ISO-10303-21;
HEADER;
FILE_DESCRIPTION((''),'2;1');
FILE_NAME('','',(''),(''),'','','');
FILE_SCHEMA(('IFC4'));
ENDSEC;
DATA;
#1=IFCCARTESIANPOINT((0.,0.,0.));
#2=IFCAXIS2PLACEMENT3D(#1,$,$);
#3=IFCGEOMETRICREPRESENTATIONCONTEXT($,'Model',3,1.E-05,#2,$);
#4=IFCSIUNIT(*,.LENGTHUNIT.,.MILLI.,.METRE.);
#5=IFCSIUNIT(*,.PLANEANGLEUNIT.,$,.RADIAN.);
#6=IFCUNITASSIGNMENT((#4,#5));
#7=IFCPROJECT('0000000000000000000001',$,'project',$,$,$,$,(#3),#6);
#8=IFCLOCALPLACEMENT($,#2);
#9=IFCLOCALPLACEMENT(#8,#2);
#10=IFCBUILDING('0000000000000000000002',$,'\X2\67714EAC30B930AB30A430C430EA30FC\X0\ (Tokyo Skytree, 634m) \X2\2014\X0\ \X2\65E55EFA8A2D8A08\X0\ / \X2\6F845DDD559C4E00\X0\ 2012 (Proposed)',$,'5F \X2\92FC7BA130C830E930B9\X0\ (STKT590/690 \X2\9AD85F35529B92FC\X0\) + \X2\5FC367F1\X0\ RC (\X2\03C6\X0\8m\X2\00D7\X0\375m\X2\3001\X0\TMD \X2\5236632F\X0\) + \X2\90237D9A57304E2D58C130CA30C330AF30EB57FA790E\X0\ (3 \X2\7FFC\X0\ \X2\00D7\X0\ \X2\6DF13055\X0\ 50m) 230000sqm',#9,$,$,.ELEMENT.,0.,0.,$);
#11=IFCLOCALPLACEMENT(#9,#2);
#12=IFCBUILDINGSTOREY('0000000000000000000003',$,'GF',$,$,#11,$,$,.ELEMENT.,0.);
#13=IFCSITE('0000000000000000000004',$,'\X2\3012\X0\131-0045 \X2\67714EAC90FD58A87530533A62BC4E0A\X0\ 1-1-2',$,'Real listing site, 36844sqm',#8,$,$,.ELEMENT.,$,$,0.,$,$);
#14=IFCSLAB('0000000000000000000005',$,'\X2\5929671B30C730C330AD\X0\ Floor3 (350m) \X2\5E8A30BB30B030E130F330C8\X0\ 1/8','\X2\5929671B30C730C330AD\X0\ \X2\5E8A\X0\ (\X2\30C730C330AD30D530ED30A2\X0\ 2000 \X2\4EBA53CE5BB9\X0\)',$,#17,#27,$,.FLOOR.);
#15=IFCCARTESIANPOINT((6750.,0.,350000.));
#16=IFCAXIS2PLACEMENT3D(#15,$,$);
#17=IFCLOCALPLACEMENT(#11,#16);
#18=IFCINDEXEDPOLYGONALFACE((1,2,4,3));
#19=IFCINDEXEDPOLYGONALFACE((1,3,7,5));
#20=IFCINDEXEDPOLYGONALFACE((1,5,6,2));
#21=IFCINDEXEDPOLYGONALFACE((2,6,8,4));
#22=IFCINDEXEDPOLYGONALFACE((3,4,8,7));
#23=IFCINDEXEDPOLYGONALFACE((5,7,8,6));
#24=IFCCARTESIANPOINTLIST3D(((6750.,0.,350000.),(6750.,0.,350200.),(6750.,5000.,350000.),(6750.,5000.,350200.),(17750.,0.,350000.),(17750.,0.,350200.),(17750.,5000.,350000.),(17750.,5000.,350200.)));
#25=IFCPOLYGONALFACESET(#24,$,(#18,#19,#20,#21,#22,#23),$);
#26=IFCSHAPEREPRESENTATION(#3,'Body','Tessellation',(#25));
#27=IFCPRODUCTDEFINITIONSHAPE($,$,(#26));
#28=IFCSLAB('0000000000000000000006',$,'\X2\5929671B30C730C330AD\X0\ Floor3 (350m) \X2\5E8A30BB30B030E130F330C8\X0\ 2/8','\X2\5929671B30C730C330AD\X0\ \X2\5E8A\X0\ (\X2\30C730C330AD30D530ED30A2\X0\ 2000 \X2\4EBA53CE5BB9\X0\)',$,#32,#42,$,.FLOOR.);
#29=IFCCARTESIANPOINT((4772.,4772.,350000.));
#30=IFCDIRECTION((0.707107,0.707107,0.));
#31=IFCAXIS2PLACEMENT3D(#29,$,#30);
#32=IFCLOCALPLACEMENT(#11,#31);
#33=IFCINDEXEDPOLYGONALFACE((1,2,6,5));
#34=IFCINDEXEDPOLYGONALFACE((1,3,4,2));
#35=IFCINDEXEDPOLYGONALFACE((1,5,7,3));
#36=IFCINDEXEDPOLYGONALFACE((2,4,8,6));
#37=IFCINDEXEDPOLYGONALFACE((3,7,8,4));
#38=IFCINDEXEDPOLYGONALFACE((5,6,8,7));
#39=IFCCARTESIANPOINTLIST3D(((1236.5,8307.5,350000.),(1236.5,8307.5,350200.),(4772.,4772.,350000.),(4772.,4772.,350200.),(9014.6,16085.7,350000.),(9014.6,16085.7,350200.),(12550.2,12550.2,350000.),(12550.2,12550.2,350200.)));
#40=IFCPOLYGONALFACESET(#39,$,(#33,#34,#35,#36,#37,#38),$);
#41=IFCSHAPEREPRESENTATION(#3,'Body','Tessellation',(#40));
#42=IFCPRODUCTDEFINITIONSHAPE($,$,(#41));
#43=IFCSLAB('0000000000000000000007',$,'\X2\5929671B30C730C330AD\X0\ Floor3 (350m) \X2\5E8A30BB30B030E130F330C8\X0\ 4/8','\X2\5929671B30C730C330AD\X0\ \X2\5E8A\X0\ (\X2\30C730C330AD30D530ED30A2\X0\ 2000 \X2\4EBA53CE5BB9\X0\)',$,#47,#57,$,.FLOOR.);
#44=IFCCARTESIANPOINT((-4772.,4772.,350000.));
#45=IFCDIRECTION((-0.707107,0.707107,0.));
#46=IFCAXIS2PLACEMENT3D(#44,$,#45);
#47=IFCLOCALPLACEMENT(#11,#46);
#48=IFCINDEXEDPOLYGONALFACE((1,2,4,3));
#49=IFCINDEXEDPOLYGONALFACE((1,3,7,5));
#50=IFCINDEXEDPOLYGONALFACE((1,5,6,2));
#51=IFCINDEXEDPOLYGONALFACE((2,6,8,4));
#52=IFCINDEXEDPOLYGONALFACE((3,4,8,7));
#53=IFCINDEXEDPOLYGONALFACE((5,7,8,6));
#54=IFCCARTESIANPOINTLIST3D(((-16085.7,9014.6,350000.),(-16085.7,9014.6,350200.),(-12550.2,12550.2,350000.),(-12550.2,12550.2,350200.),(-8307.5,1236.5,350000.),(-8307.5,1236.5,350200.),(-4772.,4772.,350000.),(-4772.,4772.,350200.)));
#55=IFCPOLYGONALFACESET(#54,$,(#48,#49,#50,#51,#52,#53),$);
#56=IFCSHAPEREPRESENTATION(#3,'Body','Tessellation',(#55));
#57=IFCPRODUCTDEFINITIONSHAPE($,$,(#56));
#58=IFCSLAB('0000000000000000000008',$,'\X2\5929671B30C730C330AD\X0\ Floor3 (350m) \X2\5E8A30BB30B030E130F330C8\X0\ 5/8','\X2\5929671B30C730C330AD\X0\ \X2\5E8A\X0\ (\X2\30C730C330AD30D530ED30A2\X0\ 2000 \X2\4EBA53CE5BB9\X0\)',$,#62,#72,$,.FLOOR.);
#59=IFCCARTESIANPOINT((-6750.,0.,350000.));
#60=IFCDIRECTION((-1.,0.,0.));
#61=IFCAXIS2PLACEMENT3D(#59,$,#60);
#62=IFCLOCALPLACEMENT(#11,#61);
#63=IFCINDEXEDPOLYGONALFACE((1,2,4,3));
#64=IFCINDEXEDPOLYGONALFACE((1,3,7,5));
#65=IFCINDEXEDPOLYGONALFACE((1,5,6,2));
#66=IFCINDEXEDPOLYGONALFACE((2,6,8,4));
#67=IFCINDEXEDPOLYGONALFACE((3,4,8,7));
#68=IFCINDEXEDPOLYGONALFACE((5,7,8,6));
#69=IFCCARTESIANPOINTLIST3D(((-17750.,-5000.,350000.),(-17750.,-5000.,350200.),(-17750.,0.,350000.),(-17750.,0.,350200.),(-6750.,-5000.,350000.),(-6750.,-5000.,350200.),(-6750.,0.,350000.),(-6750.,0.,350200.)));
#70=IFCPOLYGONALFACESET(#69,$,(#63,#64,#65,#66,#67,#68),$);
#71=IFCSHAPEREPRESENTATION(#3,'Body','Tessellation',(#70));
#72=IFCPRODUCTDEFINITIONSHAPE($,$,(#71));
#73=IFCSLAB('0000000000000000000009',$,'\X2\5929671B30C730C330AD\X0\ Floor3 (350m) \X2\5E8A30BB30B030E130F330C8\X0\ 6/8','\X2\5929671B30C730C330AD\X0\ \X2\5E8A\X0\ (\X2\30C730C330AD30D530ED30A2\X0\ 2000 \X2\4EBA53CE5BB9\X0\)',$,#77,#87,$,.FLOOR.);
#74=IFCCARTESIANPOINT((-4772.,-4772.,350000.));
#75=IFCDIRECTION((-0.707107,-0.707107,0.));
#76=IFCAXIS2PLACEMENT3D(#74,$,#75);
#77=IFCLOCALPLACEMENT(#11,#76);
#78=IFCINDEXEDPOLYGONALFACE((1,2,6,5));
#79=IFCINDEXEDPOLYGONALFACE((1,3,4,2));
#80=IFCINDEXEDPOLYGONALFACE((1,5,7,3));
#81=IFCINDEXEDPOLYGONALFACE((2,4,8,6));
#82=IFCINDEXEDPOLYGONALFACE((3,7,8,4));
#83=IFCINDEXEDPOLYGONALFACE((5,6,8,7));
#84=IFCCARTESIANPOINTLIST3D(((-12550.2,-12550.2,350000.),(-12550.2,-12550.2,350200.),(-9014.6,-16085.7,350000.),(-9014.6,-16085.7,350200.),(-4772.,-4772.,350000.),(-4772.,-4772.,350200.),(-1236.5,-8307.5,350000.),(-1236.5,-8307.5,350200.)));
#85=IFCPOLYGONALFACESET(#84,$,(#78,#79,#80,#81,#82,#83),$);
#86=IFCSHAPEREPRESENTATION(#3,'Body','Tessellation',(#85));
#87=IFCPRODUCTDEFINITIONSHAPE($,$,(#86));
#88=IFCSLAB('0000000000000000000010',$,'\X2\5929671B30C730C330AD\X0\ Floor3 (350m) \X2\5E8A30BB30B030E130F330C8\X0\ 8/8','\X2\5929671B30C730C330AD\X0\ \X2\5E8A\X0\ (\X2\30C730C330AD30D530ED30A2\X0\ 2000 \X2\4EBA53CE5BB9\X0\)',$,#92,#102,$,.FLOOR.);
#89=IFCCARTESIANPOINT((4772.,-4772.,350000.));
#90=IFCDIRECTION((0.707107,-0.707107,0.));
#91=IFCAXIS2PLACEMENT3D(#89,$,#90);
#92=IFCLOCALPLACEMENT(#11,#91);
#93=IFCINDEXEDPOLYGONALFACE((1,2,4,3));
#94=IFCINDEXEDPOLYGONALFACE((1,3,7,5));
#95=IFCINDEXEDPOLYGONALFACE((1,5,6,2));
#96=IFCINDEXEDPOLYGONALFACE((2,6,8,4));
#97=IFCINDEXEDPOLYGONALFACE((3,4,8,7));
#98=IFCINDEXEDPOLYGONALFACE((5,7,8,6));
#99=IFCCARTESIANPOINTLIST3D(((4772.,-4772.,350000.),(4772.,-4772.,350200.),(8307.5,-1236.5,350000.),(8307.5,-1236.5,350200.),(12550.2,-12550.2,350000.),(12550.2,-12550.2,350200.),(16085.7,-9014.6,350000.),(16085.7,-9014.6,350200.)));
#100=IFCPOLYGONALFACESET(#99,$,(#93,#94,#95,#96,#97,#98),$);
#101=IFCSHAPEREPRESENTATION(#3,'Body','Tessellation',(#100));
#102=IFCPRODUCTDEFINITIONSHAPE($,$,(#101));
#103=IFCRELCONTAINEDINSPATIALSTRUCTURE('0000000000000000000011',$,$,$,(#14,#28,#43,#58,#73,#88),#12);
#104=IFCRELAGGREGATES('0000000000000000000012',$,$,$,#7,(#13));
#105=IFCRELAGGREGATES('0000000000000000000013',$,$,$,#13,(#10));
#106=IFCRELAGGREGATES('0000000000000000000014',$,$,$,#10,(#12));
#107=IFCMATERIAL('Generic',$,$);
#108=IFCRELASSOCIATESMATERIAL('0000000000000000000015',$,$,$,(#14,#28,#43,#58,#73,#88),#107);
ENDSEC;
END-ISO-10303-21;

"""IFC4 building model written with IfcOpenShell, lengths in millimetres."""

from ifc_helpers import new_model, si_unit, frame, frame_2d, origin, place, context, project, spatial, rectangle, extrude, material, element, save


model = new_model("IFC4")

# Units and contexts
model_context = context("Model", 3, precision=1e-05, world=origin())
ifc_project = project(units=[si_unit("LENGTHUNIT", "METRE", prefix="MILLI"), si_unit("PLANEANGLEUNIT", "RADIAN")], contexts=[model_context])

# Site, building, storey
site_placement = place(None, origin())
site = spatial("IfcSite", under=ifc_project, at=site_placement, Name="〒131-0045 東京都墨田区押上 1-1-2", ObjectType="Real listing site, 36844sqm", CompositionType="ELEMENT", RefElevation=0.0)
building_placement = place(site_placement, origin())
building = spatial("IfcBuilding", under=site, at=building_placement, Name="東京スカイツリー (Tokyo Skytree, 634m) — 日建設計 / 澄川喜一 2012 (Proposed)", ObjectType="5F 鋼管トラス (STKT590/690 高張力鋼) + 心柱 RC (φ8m×375m、TMD 制振) + 連続地中壁ナックル基礎 (3 翼 × 深さ 50m) 230000sqm", CompositionType="ELEMENT", ElevationOfRefHeight=0.0, ElevationOfTerrain=0.0)
storey_placement = place(building_placement, origin())
storey = spatial("IfcBuildingStorey", under=building, at=storey_placement, Name="GF", CompositionType="ELEMENT", Elevation=0.0)

# Shared definitions
ifc_material_1 = material(Name="Generic")

# Slabs
slab_1_placement = place(storey_placement, frame((6750.0, 0.0, 350000.0)))
element("IfcSlab", 1, at=slab_1_placement, inside=storey, material=ifc_material_1, Name="天望デッキ Floor3 (350m) 床セグメント 1/8", Description="天望デッキ 床 (デッキフロア 2000 人収容)", PredefinedType="FLOOR", context=model_context, shape_type="SweptSolid", body=[
    extrude(rectangle(XDim=11000.0, YDim=5000.0, at=frame_2d((5500.0, 2500.0))), frame((6750.0, 0.0, 350000.0)), (0.0, 0.0, 1.0), 200.0),
])
slab_2_placement = place(storey_placement, frame((4772.0, 4772.0, 350000.0), x_axis=(0.707107, 0.707107, 0.0)))
element("IfcSlab", 2, at=slab_2_placement, inside=storey, material=ifc_material_1, Name="天望デッキ Floor3 (350m) 床セグメント 2/8", Description="天望デッキ 床 (デッキフロア 2000 人収容)", PredefinedType="FLOOR", context=model_context, shape_type="SweptSolid", body=[
    extrude(rectangle(XDim=11000.0, YDim=5000.0, at=frame_2d((5500.0, 2500.0))), frame((4772.0, 4772.0, 350000.0), x_axis=(0.707107, 0.707107, 0.0)), (0.0, 0.0, 1.0), 200.0),
])
slab_3_placement = place(storey_placement, frame((-4772.0, 4772.0, 350000.0), x_axis=(-0.707107, 0.707107, 0.0)))
element("IfcSlab", 3, at=slab_3_placement, inside=storey, material=ifc_material_1, Name="天望デッキ Floor3 (350m) 床セグメント 4/8", Description="天望デッキ 床 (デッキフロア 2000 人収容)", PredefinedType="FLOOR", context=model_context, shape_type="SweptSolid", body=[
    extrude(rectangle(XDim=11000.0, YDim=5000.0, at=frame_2d((5500.0, 2500.0))), frame((-4772.0, 4772.0, 350000.0), x_axis=(-0.707107, 0.707107, 0.0)), (0.0, 0.0, 1.0), 200.0),
])
slab_4_placement = place(storey_placement, frame((-6750.0, 0.0, 350000.0), x_axis=(-1.0, 0.0, 0.0)))
element("IfcSlab", 4, at=slab_4_placement, inside=storey, material=ifc_material_1, Name="天望デッキ Floor3 (350m) 床セグメント 5/8", Description="天望デッキ 床 (デッキフロア 2000 人収容)", PredefinedType="FLOOR", context=model_context, shape_type="SweptSolid", body=[
    extrude(rectangle(XDim=11000.0, YDim=5000.0, at=frame_2d((5500.0, 2500.0))), frame((-6750.0, 0.0, 350000.0), x_axis=(-1.0, 0.0, 0.0)), (0.0, 0.0, 1.0), 200.0),
])
slab_5_placement = place(storey_placement, frame((-4772.0, -4772.0, 350000.0), x_axis=(-0.707107, -0.707107, 0.0)))
element("IfcSlab", 5, at=slab_5_placement, inside=storey, material=ifc_material_1, Name="天望デッキ Floor3 (350m) 床セグメント 6/8", Description="天望デッキ 床 (デッキフロア 2000 人収容)", PredefinedType="FLOOR", context=model_context, shape_type="SweptSolid", body=[
    extrude(rectangle(XDim=11000.0, YDim=5000.0, at=frame_2d((5500.0, 2500.0))), frame((-4772.0, -4772.0, 350000.0), x_axis=(-0.707107, -0.707107, 0.0)), (0.0, 0.0, 1.0), 200.0),
])
slab_6_placement = place(storey_placement, frame((4772.0, -4772.0, 350000.0), x_axis=(0.707107, -0.707107, 0.0)))
element("IfcSlab", 6, at=slab_6_placement, inside=storey, material=ifc_material_1, Name="天望デッキ Floor3 (350m) 床セグメント 8/8", Description="天望デッキ 床 (デッキフロア 2000 人収容)", PredefinedType="FLOOR", context=model_context, shape_type="SweptSolid", body=[
    extrude(rectangle(XDim=11000.0, YDim=5000.0, at=frame_2d((5500.0, 2500.0))), frame((4772.0, -4772.0, 350000.0), x_axis=(0.707107, -0.707107, 0.0)), (0.0, 0.0, 1.0), 200.0),
])

save(model, "model.ifc")
